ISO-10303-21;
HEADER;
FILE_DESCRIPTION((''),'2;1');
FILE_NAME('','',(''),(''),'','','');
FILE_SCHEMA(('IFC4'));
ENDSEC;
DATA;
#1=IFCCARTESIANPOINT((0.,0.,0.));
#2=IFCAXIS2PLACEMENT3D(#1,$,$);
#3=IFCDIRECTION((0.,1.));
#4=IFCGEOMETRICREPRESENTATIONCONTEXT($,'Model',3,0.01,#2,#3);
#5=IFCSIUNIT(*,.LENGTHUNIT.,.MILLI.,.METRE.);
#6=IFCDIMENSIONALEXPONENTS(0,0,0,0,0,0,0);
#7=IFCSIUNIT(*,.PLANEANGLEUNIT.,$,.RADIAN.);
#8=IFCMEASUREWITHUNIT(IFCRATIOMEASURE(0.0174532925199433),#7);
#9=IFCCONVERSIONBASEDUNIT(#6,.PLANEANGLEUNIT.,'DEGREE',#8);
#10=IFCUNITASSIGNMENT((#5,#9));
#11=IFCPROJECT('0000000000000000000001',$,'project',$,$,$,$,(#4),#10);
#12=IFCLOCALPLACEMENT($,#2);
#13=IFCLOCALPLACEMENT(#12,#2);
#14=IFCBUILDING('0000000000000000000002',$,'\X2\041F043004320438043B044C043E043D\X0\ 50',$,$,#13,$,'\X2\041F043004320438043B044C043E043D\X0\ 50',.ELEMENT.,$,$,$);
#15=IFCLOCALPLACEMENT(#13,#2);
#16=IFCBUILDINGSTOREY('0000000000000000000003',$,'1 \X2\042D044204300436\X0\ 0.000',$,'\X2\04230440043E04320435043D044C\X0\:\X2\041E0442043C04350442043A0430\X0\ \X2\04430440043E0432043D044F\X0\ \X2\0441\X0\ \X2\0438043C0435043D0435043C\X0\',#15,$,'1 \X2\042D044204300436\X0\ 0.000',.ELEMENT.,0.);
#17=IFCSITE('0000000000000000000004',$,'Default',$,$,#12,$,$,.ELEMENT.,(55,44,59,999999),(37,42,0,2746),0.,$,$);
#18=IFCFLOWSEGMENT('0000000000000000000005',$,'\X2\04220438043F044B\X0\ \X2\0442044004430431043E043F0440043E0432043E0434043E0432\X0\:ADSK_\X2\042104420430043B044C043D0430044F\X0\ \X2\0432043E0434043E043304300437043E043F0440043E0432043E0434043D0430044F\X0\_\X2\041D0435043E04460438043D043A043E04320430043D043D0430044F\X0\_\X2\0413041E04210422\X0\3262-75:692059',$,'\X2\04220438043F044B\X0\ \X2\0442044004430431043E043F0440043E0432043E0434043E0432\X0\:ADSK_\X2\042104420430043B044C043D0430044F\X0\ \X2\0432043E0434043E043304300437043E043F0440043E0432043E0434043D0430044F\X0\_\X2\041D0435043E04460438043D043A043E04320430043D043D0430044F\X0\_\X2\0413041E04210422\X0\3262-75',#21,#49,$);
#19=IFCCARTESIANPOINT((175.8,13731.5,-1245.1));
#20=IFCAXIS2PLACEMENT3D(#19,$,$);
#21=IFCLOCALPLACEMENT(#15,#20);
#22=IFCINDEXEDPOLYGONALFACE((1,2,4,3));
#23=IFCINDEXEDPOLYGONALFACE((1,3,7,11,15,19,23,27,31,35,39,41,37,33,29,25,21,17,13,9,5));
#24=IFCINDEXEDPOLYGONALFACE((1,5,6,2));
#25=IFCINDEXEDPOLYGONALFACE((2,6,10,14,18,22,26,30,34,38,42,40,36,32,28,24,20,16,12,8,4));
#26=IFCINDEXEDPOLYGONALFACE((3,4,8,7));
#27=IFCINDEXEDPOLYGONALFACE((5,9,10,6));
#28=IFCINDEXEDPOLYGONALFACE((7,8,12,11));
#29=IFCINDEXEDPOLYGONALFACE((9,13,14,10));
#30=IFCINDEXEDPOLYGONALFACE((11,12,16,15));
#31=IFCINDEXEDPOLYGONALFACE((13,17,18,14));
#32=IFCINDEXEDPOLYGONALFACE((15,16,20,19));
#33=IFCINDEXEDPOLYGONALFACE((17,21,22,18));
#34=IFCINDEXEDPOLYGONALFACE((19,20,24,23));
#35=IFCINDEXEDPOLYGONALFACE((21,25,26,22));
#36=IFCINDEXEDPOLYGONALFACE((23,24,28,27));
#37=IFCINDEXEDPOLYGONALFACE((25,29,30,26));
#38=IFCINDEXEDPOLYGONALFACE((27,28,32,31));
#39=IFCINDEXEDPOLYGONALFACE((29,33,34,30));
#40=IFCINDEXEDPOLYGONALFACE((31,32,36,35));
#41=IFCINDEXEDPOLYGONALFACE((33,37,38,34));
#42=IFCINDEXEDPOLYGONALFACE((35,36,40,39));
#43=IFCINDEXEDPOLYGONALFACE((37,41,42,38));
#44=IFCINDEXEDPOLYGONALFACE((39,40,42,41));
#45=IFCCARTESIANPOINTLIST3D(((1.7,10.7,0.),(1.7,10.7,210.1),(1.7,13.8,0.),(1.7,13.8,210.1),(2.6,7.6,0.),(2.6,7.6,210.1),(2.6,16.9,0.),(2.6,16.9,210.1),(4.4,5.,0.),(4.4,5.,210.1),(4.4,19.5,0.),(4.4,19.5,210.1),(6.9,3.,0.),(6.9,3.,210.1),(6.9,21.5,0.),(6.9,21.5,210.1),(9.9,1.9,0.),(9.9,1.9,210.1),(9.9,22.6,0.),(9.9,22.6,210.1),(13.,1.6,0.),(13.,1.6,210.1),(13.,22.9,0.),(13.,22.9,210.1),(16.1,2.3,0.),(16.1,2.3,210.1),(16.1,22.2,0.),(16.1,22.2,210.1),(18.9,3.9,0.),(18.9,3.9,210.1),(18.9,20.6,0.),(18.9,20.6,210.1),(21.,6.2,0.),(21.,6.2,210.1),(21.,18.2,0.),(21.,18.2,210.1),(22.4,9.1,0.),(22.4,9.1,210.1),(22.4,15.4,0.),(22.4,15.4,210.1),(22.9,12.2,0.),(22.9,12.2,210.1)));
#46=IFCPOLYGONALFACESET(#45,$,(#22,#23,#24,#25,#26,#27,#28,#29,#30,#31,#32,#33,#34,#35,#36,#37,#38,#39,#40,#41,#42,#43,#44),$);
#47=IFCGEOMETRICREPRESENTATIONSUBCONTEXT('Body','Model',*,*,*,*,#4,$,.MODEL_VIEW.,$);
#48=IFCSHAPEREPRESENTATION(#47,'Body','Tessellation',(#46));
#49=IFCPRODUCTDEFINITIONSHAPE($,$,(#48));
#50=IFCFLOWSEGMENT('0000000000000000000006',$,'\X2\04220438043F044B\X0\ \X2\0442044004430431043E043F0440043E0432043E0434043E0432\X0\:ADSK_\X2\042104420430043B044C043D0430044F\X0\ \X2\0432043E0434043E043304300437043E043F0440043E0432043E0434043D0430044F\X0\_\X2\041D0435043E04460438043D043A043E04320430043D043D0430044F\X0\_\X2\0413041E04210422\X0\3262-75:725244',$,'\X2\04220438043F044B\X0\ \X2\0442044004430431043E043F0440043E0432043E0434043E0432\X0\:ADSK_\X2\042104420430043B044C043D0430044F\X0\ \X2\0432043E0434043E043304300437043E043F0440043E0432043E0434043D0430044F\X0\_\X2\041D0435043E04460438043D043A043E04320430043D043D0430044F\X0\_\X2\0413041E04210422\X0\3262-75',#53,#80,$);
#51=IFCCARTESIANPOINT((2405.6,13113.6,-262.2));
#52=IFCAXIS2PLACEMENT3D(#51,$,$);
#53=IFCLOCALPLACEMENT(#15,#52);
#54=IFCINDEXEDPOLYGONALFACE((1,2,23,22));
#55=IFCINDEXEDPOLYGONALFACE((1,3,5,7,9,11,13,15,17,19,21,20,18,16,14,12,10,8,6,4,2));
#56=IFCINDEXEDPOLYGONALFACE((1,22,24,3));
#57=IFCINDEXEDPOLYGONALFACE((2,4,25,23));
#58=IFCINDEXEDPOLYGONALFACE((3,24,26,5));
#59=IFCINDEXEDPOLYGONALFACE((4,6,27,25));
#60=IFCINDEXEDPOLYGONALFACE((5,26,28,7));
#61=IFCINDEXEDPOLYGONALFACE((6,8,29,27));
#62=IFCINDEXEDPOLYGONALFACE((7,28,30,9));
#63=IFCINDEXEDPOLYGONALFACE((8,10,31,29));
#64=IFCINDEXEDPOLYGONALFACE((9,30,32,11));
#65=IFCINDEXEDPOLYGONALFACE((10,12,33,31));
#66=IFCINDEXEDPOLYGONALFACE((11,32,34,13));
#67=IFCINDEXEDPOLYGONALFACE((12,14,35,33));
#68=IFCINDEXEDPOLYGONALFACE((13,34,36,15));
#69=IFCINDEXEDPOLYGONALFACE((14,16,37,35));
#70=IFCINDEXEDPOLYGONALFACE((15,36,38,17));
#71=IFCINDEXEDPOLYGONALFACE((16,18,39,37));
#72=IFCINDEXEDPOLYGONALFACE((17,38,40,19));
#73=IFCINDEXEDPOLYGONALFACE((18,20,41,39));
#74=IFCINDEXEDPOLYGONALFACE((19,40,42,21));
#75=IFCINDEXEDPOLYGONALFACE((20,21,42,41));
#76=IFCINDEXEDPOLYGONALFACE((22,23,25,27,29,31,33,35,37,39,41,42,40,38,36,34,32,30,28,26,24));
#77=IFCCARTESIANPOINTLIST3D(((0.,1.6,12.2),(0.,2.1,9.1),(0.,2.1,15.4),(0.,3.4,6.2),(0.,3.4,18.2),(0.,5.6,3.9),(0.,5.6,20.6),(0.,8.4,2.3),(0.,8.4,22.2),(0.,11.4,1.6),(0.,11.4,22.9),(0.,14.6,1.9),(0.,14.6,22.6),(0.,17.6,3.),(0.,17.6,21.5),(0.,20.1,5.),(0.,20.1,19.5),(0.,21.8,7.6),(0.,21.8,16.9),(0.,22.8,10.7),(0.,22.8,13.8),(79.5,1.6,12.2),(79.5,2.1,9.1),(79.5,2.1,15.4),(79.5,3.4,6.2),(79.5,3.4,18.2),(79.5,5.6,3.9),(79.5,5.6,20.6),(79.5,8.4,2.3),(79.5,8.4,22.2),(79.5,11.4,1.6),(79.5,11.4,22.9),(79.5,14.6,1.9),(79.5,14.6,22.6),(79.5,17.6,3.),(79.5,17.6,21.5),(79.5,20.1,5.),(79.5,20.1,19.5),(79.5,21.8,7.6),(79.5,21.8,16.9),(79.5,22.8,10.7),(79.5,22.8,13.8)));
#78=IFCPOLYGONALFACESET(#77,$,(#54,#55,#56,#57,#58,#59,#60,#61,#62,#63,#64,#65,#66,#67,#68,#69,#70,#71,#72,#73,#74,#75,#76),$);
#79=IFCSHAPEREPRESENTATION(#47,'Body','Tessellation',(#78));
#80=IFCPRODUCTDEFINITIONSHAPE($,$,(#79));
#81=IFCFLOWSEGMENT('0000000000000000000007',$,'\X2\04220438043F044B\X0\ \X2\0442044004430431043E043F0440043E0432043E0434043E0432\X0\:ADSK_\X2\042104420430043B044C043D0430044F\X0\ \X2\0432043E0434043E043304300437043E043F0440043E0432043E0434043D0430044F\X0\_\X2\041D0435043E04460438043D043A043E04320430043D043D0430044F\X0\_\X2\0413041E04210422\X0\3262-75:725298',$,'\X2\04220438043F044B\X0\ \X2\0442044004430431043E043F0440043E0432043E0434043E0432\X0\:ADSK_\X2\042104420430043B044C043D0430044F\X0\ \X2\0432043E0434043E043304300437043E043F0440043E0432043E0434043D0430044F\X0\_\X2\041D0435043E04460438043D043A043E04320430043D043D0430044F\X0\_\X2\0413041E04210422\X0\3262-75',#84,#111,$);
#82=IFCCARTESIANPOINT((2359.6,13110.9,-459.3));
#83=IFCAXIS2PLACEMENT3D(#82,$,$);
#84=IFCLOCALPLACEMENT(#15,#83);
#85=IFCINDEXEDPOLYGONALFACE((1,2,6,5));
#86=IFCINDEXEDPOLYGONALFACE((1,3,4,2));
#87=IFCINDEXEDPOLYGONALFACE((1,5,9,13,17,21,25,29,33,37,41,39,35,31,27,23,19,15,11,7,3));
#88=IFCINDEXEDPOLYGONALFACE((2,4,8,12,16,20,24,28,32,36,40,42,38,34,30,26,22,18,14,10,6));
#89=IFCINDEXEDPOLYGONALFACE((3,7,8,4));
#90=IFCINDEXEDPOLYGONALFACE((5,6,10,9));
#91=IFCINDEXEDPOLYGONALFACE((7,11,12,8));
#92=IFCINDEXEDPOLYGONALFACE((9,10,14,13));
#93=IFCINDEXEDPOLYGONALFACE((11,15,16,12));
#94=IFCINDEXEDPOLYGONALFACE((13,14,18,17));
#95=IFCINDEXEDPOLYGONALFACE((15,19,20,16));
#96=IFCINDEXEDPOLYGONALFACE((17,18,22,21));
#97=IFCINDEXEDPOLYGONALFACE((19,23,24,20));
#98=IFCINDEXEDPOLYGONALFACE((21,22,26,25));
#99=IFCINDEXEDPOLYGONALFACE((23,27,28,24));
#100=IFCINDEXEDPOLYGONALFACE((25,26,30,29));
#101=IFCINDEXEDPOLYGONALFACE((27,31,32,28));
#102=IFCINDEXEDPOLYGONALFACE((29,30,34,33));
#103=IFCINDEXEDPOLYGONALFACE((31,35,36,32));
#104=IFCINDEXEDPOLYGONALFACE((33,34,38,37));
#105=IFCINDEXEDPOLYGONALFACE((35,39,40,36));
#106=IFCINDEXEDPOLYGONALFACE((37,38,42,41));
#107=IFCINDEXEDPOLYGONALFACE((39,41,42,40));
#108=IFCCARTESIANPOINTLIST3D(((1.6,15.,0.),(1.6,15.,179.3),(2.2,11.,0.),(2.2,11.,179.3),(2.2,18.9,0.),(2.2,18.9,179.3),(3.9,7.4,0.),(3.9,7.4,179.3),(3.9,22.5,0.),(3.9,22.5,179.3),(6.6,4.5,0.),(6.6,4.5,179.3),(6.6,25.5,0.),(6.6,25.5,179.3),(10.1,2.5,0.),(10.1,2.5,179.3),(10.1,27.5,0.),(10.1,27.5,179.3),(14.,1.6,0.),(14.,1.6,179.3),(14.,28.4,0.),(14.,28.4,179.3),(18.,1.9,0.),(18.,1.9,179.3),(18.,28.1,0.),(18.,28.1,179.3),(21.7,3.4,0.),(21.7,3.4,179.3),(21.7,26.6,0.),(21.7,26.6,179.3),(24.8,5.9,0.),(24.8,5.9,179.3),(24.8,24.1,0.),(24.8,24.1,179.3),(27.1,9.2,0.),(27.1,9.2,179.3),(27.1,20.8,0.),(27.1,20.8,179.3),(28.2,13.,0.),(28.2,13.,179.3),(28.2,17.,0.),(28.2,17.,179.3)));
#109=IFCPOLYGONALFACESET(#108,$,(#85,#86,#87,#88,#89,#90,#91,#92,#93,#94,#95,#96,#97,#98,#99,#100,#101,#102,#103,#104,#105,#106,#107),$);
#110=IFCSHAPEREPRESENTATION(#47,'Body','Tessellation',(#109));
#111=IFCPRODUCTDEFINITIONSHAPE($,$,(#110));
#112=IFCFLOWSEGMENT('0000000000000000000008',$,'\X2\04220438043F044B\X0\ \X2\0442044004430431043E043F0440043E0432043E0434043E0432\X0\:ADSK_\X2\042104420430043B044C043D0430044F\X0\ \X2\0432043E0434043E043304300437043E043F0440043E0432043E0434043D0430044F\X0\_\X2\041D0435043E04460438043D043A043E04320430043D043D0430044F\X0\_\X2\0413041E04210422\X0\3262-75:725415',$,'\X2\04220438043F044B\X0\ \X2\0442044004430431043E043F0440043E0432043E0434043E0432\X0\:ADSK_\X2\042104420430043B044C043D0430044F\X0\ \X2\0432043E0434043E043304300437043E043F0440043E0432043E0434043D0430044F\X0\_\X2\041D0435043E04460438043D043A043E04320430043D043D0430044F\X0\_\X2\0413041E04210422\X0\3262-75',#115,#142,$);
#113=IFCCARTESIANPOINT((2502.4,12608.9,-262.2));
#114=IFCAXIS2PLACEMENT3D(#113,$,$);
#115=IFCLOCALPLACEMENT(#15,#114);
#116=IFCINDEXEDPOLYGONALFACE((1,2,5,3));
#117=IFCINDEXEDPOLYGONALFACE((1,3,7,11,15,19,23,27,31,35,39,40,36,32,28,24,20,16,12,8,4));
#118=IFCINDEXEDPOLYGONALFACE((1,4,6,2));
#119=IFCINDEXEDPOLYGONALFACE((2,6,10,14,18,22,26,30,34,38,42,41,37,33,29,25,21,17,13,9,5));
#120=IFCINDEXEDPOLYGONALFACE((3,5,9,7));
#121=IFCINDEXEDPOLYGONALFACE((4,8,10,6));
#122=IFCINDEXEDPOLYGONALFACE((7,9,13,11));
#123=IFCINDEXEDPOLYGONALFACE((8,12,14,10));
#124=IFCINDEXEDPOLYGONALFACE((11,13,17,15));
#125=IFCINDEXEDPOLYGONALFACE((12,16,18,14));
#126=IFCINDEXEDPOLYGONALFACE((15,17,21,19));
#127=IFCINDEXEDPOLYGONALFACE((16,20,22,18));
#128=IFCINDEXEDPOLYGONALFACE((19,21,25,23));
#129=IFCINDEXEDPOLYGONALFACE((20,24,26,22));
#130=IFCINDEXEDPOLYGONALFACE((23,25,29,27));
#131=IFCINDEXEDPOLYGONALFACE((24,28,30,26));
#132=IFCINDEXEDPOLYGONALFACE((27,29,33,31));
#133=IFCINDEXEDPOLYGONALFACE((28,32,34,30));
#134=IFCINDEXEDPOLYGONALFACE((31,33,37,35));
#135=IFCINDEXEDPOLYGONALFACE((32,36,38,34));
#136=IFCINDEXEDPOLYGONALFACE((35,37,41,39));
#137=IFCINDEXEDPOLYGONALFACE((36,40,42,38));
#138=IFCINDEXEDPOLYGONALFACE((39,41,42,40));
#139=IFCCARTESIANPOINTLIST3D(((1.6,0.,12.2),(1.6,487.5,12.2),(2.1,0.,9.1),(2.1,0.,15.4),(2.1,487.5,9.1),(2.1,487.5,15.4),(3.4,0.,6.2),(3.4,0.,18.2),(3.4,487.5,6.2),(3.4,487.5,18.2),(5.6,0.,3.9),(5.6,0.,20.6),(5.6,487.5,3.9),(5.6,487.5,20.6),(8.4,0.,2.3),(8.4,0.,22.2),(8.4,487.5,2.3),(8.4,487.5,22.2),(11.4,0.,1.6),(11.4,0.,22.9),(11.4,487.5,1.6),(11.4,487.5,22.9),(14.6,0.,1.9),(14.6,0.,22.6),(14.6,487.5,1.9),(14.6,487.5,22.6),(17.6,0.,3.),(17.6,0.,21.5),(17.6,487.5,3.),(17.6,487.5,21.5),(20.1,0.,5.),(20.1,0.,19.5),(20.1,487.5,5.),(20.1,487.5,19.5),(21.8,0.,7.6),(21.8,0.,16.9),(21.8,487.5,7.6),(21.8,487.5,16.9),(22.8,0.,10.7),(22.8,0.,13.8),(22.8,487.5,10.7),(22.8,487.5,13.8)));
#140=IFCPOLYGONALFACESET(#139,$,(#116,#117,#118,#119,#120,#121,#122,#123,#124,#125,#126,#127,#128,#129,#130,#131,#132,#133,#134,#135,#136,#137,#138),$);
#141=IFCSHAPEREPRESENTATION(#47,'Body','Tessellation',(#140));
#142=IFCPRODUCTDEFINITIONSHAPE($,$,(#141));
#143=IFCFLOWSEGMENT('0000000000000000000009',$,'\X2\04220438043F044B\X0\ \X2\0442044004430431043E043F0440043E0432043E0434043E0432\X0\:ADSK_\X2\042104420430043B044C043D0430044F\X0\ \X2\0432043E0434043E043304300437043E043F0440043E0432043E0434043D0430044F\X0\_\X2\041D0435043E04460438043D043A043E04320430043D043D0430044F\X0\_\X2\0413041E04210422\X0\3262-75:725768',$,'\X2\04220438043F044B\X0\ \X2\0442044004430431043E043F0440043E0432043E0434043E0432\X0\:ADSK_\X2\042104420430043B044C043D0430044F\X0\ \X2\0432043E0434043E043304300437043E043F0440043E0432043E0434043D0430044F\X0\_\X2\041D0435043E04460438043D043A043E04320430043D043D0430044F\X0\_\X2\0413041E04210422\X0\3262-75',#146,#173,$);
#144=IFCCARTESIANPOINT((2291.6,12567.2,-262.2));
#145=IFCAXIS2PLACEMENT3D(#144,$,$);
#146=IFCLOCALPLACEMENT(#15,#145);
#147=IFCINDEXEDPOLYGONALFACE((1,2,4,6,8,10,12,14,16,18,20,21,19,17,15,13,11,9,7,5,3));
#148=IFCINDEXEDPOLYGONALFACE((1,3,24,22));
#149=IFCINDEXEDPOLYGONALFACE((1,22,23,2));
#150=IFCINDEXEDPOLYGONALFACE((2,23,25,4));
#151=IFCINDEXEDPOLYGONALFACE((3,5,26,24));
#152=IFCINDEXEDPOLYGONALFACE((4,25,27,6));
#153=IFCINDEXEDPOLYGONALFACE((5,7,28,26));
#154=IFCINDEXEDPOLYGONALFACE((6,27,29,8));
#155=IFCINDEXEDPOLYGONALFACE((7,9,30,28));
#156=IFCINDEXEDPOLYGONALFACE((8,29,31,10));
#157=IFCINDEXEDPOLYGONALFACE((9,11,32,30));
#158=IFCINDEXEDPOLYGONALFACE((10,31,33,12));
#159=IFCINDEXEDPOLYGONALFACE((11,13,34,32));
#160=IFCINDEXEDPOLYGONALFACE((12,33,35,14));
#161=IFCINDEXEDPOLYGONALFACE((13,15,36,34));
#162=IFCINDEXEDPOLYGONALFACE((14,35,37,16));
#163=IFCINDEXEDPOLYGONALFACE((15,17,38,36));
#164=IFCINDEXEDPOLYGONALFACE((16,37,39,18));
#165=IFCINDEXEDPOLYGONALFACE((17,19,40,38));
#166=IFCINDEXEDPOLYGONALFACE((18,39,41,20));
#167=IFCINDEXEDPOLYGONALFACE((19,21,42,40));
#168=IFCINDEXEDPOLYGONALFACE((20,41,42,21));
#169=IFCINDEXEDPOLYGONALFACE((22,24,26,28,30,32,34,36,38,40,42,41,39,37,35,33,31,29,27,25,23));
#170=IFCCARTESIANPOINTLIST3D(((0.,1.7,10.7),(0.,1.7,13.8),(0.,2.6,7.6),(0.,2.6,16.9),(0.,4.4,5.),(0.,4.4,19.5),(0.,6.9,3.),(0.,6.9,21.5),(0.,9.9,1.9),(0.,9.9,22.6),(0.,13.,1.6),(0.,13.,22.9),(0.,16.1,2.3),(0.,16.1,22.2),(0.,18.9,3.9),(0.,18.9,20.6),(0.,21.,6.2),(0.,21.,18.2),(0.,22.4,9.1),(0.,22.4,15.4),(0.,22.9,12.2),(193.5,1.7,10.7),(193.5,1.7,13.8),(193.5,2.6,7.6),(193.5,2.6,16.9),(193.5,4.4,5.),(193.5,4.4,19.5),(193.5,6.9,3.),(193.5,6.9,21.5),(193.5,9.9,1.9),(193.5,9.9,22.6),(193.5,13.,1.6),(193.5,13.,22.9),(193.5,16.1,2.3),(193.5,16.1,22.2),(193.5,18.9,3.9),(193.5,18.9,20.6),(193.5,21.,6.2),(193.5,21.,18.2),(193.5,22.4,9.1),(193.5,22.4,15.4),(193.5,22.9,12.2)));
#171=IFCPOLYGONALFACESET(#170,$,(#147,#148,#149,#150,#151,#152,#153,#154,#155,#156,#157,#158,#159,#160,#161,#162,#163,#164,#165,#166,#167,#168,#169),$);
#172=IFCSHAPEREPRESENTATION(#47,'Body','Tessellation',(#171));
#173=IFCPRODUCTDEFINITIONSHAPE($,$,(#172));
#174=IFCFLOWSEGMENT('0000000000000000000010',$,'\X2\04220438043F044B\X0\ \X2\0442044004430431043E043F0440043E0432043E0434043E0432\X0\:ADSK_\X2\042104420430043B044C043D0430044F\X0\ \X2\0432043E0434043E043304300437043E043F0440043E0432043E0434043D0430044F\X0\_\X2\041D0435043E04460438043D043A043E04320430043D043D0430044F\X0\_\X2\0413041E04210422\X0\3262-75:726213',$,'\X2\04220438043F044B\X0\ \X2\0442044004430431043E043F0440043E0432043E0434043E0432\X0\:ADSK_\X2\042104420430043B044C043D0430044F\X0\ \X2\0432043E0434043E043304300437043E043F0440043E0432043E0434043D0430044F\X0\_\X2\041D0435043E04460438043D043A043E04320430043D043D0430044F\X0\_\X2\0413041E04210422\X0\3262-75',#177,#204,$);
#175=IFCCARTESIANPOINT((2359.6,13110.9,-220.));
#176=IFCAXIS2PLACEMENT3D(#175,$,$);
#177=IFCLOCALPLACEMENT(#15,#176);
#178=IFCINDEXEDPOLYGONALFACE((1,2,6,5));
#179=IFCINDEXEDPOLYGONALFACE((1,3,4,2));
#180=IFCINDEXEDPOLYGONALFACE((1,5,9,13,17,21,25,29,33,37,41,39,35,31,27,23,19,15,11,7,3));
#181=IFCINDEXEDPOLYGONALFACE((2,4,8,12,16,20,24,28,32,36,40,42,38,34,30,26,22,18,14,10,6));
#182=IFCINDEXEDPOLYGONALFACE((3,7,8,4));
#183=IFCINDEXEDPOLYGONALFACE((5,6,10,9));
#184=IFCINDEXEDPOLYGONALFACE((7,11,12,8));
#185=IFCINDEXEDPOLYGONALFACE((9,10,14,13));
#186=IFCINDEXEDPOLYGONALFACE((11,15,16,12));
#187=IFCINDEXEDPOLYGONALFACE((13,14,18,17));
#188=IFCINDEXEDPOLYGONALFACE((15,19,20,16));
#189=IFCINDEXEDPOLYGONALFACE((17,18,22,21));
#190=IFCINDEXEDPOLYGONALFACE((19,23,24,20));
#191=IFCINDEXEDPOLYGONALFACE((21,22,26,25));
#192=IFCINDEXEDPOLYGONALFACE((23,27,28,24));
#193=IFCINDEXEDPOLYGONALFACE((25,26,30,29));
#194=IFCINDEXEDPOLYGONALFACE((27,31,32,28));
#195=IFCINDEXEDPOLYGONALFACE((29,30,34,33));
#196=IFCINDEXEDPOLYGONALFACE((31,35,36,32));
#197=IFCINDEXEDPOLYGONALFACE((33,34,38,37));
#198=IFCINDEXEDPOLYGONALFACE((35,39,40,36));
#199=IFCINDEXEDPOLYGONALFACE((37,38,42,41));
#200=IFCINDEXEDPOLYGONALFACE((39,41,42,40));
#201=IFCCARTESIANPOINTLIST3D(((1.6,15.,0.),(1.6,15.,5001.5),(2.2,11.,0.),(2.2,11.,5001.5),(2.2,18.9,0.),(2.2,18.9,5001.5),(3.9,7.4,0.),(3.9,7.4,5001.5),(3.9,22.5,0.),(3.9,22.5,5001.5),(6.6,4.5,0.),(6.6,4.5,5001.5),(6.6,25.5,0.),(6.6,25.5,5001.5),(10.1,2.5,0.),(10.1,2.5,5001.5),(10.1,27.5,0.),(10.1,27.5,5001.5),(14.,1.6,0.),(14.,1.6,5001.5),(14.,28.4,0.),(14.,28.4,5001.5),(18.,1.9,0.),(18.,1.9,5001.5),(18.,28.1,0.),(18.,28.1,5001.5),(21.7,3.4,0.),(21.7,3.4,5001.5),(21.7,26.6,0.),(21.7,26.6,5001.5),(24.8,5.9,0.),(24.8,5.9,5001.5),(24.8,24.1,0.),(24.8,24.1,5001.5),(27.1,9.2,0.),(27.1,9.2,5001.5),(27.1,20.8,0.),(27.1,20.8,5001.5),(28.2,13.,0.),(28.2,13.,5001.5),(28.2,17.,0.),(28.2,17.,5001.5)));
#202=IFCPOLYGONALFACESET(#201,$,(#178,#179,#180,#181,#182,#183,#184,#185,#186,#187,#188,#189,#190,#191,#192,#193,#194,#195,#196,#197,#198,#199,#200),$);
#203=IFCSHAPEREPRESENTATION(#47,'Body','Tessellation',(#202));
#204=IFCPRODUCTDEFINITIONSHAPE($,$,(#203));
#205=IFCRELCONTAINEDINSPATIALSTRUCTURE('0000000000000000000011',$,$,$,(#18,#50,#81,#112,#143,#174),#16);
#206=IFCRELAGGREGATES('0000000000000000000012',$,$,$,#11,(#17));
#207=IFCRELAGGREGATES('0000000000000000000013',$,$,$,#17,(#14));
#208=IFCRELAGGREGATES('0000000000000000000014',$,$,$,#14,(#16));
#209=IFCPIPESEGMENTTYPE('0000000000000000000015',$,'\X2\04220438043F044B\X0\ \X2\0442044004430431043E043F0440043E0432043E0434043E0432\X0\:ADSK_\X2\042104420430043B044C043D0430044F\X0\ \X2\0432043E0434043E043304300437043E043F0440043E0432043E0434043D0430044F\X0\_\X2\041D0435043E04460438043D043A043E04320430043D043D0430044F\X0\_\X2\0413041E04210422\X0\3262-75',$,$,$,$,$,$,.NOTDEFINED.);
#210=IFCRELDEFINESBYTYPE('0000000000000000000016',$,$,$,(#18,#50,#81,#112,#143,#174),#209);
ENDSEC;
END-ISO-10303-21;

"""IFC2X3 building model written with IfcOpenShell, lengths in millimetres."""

from ifc_helpers import new_model, entity, si_unit, converted_unit, direction, frame, frame_2d, origin, origin_2d_with_axis, place, context, subcontext, project, spatial, circle, extrude, type_object, element, save


model = new_model("IFC2X3")

# Units and contexts
model_context = context("Model", 3, precision=0.01, world=origin(), true_north=direction((0.0, 1.0)))
body_context = subcontext(model_context, "Body", "Model", "MODEL_VIEW")
ifc_project = project(units=[si_unit("LENGTHUNIT", "METRE", prefix="MILLI"), converted_unit("PLANEANGLEUNIT", "DEGREE", entity("IfcRatioMeasure", 0.0174532925199433), si_unit("PLANEANGLEUNIT", "RADIAN"), dimensions=[0, 0, 0, 0, 0, 0, 0])], contexts=[model_context])

# Site, building, storey
site_placement = place(None, origin())
site = spatial("IfcSite", under=ifc_project, at=site_placement, Name="Default", CompositionType="ELEMENT", RefLatitude=(55, 44, 59, 999999), RefLongitude=(37, 42, 0, 2746), RefElevation=0.0)
building_placement = place(site_placement, origin())
building = spatial("IfcBuilding", under=site, at=building_placement, Name="Павильон 50", LongName="Павильон 50", CompositionType="ELEMENT")
storey_placement = place(building_placement, origin())
storey = spatial("IfcBuildingStorey", under=building, at=storey_placement, Name="1 Этаж 0.000", ObjectType="Уровень:Отметка уровня с именем", LongName="1 Этаж 0.000", CompositionType="ELEMENT", Elevation=0.0)

# Flow segments
pipe_segment_type = type_object("IfcPipeSegmentType", Name="Типы трубопроводов:ADSK_Стальная водогазопроводная_Неоцинкованная_ГОСТ3262-75", PredefinedType="NOTDEFINED")
flow_segment_1_placement = place(storey_placement, frame((175.8, 13731.5, -1245.1)))
element("IfcFlowSegment", 1, at=flow_segment_1_placement, inside=storey, type_object=pipe_segment_type, Name="Типы трубопроводов:ADSK_Стальная водогазопроводная_Неоцинкованная_ГОСТ3262-75:692059", ObjectType="Типы трубопроводов:ADSK_Стальная водогазопроводная_Неоцинкованная_ГОСТ3262-75", context=body_context, shape_type="SweptSolid", body=[
    extrude(circle(Radius=10.7, at=frame_2d((0.0, 0.0), x_axis=(1.0, 0.0))), frame((12.2, 12.2, 0.0)), (0.0, 0.0, 1.0), 210.1),
])
flow_segment_2_placement = place(storey_placement, frame((2405.6, 13113.6, -262.2)))
element("IfcFlowSegment", 2, at=flow_segment_2_placement, inside=storey, type_object=pipe_segment_type, Name="Типы трубопроводов:ADSK_Стальная водогазопроводная_Неоцинкованная_ГОСТ3262-75:725244", ObjectType="Типы трубопроводов:ADSK_Стальная водогазопроводная_Неоцинкованная_ГОСТ3262-75", context=body_context, shape_type="SweptSolid", body=[
    extrude(circle(Radius=10.7, at=origin_2d_with_axis()), frame((0.0, 12.2, 12.2), z_axis=(1.0, 0.0, 0.0), x_axis=(0.0, -1.0, 0.0)), (0.0, 0.0, 1.0), 79.5),
])
flow_segment_3_placement = place(storey_placement, frame((2359.6, 13110.9, -459.3)))
element("IfcFlowSegment", 3, at=flow_segment_3_placement, inside=storey, type_object=pipe_segment_type, Name="Типы трубопроводов:ADSK_Стальная водогазопроводная_Неоцинкованная_ГОСТ3262-75:725298", ObjectType="Типы трубопроводов:ADSK_Стальная водогазопроводная_Неоцинкованная_ГОСТ3262-75", context=body_context, shape_type="SweptSolid", body=[
    extrude(circle(Radius=13.4, at=frame_2d((0.0, 0.0), x_axis=(1.0, 0.0))), frame((15.0, 15.0, 0.0), z_axis=(0.0, 0.0, 1.0), x_axis=(-1.0, 0.0, 0.0)), (0.0, 0.0, 1.0), 179.3),
])
flow_segment_4_placement = place(storey_placement, frame((2502.4, 12608.9, -262.2)))
element("IfcFlowSegment", 4, at=flow_segment_4_placement, inside=storey, type_object=pipe_segment_type, Name="Типы трубопроводов:ADSK_Стальная водогазопроводная_Неоцинкованная_ГОСТ3262-75:725415", ObjectType="Типы трубопроводов:ADSK_Стальная водогазопроводная_Неоцинкованная_ГОСТ3262-75", context=body_context, shape_type="SweptSolid", body=[
    extrude(circle(Radius=10.7, at=origin_2d_with_axis()), frame((12.2, 0.0, 12.2), z_axis=(0.0, 1.0, 0.0), x_axis=(-1.0, 0.0, 0.0)), (0.0, 0.0, 1.0), 487.5),
])
flow_segment_5_placement = place(storey_placement, frame((2291.6, 12567.2, -262.2)))
element("IfcFlowSegment", 5, at=flow_segment_5_placement, inside=storey, type_object=pipe_segment_type, Name="Типы трубопроводов:ADSK_Стальная водогазопроводная_Неоцинкованная_ГОСТ3262-75:725768", ObjectType="Типы трубопроводов:ADSK_Стальная водогазопроводная_Неоцинкованная_ГОСТ3262-75", context=body_context, shape_type="SweptSolid", body=[
    extrude(circle(Radius=10.7, at=frame_2d((0.0, 0.0), x_axis=(1.0, 0.0))), frame((0.0, 12.2, 12.2), z_axis=(1.0, 0.0, 0.0), x_axis=(0.0, 1.0, 0.0)), (0.0, 0.0, 1.0), 193.5),
])
flow_segment_6_placement = place(storey_placement, frame((2359.6, 13110.9, -220.0)))
element("IfcFlowSegment", 6, at=flow_segment_6_placement, inside=storey, type_object=pipe_segment_type, Name="Типы трубопроводов:ADSK_Стальная водогазопроводная_Неоцинкованная_ГОСТ3262-75:726213", ObjectType="Типы трубопроводов:ADSK_Стальная водогазопроводная_Неоцинкованная_ГОСТ3262-75", context=body_context, shape_type="SweptSolid", body=[
    extrude(circle(Radius=13.4, at=frame_2d((0.0, 0.0), x_axis=(1.0, 0.0))), frame((15.0, 15.0, 0.0), z_axis=(0.0, 0.0, 1.0), x_axis=(-1.0, 0.0, 0.0)), (0.0, 0.0, 1.0), 5001.5),
])

save(model, "model.ifc")
